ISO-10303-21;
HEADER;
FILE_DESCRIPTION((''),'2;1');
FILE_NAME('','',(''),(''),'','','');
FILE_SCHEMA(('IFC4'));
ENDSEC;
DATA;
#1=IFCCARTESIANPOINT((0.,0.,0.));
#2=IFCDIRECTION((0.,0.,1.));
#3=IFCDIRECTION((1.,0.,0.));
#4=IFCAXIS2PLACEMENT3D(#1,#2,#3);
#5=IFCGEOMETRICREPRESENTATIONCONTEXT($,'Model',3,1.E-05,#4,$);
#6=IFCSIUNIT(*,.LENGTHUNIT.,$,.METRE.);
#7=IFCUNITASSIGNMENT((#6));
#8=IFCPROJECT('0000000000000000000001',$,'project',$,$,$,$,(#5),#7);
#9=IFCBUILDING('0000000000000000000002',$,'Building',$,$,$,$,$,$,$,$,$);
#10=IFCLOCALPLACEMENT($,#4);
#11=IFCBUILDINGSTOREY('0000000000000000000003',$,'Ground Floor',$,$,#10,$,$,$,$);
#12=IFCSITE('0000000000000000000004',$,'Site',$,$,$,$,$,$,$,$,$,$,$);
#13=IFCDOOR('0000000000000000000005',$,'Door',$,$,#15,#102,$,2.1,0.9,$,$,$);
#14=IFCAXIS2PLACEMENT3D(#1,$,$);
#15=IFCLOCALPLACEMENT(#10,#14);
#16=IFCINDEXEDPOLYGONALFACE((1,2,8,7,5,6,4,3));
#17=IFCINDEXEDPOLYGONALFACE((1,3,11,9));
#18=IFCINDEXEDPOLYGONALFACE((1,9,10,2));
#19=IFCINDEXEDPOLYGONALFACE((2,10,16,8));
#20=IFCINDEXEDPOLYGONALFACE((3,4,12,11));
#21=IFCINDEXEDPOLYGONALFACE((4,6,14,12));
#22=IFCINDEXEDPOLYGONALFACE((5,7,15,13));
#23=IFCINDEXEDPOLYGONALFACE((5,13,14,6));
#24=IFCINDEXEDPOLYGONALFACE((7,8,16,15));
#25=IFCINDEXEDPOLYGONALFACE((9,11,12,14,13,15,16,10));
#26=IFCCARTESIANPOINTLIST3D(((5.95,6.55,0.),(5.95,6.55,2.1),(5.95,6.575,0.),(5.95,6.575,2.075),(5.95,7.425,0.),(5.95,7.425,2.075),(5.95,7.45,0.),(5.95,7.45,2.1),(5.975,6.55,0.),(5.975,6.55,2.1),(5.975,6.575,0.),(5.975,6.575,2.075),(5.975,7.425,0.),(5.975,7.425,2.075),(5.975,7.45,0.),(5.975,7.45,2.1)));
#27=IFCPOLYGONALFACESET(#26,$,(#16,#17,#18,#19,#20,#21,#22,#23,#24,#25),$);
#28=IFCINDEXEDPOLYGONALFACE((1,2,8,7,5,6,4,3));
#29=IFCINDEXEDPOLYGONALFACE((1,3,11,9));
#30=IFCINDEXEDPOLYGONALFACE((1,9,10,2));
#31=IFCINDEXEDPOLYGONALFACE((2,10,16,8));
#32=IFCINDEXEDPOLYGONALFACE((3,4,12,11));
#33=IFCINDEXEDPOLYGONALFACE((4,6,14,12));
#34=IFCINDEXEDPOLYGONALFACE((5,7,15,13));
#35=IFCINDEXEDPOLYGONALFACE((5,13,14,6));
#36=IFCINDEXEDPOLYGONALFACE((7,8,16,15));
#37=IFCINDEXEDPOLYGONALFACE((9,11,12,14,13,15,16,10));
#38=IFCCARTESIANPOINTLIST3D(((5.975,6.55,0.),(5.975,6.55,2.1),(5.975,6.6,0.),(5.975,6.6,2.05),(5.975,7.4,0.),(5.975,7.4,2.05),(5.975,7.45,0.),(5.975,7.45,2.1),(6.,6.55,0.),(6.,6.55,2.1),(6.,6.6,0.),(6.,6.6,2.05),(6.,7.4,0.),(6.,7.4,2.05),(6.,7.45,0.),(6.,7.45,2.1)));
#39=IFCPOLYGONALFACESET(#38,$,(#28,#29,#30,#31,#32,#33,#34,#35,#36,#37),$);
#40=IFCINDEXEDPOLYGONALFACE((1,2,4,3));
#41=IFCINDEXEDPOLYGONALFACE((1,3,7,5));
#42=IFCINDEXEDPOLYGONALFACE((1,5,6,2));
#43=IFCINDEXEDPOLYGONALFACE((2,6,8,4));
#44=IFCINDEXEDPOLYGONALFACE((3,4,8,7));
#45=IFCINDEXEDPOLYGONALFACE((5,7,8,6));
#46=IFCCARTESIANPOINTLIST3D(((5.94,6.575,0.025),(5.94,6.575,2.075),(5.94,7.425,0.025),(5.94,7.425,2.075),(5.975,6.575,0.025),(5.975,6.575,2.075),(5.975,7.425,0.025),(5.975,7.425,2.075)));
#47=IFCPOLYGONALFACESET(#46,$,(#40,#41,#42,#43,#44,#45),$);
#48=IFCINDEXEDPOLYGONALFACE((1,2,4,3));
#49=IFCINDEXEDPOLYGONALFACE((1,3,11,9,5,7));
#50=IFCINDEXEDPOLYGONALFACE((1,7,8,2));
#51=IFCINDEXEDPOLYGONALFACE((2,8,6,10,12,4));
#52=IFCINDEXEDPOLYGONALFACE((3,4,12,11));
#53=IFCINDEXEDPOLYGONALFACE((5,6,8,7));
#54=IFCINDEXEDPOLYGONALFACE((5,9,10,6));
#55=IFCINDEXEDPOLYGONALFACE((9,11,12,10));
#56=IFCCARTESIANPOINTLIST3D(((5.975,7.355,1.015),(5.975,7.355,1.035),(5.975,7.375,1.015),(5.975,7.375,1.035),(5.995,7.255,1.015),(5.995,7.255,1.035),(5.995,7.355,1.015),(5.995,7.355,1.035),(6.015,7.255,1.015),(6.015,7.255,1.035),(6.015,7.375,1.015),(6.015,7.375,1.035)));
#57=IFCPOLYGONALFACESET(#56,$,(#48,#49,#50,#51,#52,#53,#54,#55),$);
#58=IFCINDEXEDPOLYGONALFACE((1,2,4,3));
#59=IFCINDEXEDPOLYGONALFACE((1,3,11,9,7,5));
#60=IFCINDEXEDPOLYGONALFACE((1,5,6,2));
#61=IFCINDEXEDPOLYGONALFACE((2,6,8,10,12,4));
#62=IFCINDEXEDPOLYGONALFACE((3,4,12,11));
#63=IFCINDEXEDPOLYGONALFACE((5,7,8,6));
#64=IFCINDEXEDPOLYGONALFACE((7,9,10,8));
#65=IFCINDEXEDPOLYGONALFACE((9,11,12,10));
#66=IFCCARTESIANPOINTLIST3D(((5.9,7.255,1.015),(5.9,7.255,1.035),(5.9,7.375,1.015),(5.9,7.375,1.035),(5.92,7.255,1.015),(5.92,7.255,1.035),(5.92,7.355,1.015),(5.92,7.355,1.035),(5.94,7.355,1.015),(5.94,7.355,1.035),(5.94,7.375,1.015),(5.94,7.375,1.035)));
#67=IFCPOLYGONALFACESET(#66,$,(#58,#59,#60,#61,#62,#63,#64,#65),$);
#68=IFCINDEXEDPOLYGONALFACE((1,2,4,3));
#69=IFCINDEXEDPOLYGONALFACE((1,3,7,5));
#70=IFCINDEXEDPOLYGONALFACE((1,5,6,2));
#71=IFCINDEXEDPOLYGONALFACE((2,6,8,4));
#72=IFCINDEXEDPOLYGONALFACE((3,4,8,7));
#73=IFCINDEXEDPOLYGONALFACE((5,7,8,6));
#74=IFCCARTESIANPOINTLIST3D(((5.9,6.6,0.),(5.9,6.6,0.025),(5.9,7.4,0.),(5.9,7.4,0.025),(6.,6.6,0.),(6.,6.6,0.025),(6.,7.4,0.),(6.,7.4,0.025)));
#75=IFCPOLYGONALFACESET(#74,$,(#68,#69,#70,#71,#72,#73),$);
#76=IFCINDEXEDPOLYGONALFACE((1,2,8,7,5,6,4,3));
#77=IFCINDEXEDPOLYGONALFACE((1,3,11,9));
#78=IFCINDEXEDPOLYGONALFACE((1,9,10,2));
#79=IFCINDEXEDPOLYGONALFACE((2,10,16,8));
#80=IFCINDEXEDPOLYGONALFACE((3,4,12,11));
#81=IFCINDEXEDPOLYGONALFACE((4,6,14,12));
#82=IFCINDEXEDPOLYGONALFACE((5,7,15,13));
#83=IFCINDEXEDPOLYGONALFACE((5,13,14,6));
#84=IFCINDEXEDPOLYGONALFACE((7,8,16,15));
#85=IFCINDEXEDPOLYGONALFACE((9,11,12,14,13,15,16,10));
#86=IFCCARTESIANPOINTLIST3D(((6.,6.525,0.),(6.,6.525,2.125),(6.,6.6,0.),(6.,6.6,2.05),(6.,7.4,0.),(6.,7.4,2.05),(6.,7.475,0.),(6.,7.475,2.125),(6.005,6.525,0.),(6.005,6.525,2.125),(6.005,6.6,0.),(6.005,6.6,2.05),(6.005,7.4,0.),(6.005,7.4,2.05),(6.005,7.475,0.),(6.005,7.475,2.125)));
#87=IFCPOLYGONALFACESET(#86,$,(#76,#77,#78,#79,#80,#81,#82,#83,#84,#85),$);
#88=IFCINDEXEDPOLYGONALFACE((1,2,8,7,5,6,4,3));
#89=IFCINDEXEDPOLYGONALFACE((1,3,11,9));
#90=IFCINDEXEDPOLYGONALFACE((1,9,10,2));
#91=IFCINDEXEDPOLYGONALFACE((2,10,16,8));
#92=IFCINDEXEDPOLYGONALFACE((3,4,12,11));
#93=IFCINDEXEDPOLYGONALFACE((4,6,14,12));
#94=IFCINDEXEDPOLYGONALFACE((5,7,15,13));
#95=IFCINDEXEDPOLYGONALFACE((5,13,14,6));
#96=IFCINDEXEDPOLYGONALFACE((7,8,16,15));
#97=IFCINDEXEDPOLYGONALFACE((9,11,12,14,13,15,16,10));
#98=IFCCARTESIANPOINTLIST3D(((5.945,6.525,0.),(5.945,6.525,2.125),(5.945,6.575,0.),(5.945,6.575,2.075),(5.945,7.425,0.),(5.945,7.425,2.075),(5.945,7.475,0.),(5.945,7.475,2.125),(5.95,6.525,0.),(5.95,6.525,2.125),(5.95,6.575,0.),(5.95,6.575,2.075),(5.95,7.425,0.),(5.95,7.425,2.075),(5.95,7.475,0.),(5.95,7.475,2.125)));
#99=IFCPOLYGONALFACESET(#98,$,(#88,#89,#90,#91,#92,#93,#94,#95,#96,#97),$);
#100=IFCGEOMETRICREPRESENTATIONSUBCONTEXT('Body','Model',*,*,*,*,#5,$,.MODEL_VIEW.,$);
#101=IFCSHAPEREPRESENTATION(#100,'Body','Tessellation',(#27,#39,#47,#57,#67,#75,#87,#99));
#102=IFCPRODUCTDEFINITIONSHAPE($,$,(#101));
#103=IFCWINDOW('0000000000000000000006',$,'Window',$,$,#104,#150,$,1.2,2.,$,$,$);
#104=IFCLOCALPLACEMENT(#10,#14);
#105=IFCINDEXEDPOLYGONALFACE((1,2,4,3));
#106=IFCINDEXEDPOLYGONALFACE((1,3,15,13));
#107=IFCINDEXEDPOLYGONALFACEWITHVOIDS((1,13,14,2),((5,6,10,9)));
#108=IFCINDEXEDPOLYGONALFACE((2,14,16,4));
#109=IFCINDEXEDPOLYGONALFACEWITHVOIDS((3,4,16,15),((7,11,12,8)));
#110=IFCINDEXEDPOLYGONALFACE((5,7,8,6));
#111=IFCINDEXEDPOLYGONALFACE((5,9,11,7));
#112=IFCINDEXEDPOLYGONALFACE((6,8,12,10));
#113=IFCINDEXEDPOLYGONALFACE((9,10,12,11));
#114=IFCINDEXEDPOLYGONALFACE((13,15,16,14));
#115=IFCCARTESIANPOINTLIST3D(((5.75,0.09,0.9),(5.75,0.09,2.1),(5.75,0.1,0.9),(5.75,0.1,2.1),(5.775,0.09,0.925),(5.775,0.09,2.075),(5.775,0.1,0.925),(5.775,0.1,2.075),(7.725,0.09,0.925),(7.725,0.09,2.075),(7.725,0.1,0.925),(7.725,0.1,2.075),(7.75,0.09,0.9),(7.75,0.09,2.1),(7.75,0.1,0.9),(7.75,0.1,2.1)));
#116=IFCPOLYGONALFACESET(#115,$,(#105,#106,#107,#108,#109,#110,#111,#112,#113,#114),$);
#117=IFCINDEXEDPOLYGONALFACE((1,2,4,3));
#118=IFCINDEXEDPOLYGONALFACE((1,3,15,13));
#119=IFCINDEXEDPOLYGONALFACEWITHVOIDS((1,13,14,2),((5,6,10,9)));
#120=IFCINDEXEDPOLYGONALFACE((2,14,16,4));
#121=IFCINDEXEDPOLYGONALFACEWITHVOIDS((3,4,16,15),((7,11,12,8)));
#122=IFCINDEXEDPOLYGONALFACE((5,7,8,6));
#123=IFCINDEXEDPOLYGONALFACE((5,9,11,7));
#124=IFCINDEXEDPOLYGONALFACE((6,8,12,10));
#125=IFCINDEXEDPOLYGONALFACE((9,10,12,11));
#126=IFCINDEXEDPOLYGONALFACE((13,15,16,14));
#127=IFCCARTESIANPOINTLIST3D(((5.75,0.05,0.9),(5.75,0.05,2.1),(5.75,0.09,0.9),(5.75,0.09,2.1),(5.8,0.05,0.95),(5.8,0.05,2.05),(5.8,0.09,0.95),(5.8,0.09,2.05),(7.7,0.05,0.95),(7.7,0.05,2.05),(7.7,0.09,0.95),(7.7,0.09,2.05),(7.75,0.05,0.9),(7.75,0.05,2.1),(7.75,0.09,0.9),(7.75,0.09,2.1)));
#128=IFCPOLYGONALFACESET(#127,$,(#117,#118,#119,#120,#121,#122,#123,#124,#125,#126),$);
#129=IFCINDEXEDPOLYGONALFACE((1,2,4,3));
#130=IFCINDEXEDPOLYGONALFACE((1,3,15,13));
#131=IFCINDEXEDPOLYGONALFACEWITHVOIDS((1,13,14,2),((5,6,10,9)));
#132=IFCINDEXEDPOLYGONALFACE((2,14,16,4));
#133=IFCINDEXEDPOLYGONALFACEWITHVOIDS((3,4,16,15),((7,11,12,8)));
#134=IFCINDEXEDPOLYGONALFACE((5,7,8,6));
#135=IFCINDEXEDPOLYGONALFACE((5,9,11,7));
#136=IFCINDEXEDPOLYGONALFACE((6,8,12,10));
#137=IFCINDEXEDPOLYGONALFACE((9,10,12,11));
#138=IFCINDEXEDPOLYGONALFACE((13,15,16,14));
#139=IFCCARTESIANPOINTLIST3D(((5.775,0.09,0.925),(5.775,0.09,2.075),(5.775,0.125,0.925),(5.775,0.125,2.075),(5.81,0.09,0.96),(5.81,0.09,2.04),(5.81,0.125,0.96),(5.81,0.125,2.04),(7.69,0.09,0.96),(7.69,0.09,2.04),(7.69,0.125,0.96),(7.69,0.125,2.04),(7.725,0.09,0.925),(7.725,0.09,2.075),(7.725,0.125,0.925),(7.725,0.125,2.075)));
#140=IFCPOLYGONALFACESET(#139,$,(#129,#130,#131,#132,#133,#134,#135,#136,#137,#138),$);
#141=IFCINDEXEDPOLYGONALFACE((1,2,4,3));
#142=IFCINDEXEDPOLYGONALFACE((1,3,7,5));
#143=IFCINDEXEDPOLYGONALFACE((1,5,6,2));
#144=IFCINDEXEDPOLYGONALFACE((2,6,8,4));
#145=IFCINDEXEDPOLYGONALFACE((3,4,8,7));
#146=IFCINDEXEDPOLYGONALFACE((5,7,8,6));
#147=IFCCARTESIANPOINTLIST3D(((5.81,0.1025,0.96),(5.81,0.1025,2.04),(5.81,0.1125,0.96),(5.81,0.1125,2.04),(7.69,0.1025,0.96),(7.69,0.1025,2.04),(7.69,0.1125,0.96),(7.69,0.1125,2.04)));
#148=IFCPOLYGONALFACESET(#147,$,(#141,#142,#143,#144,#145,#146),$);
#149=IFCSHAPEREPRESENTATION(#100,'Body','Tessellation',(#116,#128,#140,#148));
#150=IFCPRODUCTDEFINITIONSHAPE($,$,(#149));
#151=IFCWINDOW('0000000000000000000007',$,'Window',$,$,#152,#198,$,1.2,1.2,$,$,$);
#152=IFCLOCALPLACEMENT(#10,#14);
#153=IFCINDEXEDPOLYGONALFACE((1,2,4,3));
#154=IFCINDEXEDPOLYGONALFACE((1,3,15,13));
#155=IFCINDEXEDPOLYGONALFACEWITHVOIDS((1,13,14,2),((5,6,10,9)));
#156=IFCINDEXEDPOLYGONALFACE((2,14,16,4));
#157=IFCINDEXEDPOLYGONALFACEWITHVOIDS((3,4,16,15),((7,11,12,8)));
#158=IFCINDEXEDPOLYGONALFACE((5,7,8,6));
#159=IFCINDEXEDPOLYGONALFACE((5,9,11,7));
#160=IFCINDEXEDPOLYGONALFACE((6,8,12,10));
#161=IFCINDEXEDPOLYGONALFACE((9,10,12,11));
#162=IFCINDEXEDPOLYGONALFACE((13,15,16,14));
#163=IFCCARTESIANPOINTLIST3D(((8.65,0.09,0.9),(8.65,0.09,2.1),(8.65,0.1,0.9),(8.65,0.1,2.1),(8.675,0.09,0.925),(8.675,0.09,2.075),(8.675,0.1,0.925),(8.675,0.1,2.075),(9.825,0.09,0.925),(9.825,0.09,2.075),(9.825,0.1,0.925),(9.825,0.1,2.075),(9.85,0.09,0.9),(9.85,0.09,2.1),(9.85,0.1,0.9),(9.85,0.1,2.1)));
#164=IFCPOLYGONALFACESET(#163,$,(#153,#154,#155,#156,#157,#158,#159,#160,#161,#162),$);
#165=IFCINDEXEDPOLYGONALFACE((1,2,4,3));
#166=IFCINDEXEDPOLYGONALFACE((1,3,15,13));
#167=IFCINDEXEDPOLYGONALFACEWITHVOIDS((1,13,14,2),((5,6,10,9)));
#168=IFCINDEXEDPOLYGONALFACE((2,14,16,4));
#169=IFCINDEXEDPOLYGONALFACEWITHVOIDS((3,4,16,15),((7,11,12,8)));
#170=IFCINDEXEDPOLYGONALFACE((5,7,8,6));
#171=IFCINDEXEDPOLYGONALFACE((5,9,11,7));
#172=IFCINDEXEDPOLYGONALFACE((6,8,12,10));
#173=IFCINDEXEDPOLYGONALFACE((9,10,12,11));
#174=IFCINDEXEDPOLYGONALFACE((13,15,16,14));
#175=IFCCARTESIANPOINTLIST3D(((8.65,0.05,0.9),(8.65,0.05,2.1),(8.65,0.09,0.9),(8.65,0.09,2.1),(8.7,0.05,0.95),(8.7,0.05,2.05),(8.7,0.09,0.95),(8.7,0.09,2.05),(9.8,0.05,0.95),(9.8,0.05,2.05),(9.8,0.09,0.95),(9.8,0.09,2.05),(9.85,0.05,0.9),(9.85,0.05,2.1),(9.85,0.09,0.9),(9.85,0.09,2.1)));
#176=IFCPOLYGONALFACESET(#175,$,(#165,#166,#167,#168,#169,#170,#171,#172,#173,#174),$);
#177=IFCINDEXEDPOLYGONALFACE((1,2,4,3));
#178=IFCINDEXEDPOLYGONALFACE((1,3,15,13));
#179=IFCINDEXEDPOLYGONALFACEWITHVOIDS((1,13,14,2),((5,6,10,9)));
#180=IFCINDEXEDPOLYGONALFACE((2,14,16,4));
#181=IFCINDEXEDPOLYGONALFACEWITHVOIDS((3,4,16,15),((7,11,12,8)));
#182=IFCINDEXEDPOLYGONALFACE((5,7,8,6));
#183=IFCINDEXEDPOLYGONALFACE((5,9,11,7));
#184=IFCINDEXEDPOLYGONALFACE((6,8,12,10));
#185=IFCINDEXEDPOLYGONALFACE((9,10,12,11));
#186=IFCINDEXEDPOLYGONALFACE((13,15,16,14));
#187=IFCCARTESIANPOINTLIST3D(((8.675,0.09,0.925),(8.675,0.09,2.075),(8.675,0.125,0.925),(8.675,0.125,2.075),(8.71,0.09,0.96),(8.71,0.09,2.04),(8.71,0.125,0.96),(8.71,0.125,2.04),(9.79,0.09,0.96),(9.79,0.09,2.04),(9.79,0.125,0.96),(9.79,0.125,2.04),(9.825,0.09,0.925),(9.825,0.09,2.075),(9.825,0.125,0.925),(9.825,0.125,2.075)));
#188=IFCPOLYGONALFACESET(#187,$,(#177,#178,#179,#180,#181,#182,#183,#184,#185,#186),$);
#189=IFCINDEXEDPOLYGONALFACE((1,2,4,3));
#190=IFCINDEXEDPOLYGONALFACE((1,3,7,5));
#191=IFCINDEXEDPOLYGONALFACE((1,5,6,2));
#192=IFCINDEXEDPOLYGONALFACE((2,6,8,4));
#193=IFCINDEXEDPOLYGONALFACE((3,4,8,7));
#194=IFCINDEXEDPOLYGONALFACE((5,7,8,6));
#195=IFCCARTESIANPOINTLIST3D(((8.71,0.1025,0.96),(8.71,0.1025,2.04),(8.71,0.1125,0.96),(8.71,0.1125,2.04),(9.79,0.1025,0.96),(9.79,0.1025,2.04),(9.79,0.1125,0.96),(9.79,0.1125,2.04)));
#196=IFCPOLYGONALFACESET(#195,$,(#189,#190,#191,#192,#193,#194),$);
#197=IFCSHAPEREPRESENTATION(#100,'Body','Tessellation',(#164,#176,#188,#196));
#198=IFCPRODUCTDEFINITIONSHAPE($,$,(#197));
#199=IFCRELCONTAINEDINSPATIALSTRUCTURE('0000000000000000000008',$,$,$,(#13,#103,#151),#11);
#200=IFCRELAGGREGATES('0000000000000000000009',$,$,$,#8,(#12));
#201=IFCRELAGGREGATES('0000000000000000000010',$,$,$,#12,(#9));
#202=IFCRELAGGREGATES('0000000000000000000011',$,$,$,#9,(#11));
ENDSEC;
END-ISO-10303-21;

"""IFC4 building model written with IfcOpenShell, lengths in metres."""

from ifc_helpers import new_model, si_unit, frame, origin_with_axes, place, context, subcontext, project, spatial, line, indexed_curve, outline, extrude, element, save


model = new_model("IFC4")

# Units and contexts
model_context = context("Model", 3, precision=1e-05, world=origin_with_axes())
body_context = subcontext(model_context, "Body", "Model", "MODEL_VIEW")
ifc_project = project(units=[si_unit("LENGTHUNIT", "METRE")], contexts=[model_context])

# Site, building, storey
site = spatial("IfcSite", under=ifc_project, Name="Site")
building = spatial("IfcBuilding", under=site, Name="Building")
storey_placement = place(None, origin_with_axes())
storey = spatial("IfcBuildingStorey", under=building, at=storey_placement, Name="Ground Floor")

# Door
door_1_placement = place(storey_placement, frame((6.0, 6.55, 0.0), z_axis=(0.0, 0.0, 1.0), x_axis=(0.0, 1.0, 0.0)))
element("IfcDoor", 1, at=door_1_placement, inside=storey, Name="Door", OverallHeight=2.1, OverallWidth=0.9, context=body_context, shape_type="SweptSolid", body=[
    extrude(outline(indexed_curve([(0.0, 0.0), (0.0, 2.1), (0.9, 2.1), (0.9, 0.0), (0.875, 0.0), (0.875, 2.075), (0.025, 2.075), (0.025, 0.0)], segments=[line(1, 2, 3, 4, 5, 6, 7, 8, 1)])), frame((0.0, 0.025, 0.0), z_axis=(0.0, -1.0, 0.0), x_axis=(1.0, 0.0, 0.0)), (0.0, 0.0, -1.0), 0.025),
    extrude(outline(indexed_curve([(0.0, 0.0), (0.0, 2.1), (0.9, 2.1), (0.9, 0.0), (0.85, 0.0), (0.85, 2.05), (0.05, 2.05), (0.05, 0.0)], segments=[line(1, 2, 3, 4, 5, 6, 7, 8, 1)])), frame((0.0, 0.0, 0.0), z_axis=(0.0, -1.0, 0.0), x_axis=(1.0, 0.0, 0.0)), (0.0, 0.0, -1.0), 0.025),
    extrude(outline(indexed_curve([(0.0, 0.0), (0.85, 0.0), (0.85, 0.035), (0.0, 0.035)], segments=[line(1, 2, 3, 4, 1)])), frame((0.025, 0.025, 0.025), z_axis=(0.0, 0.0, 1.0), x_axis=(1.0, 0.0, 0.0)), (0.0, 0.0, 1.0), 2.05),
    extrude(outline(indexed_curve([(0.0, 0.0), (0.0, -0.04), (-0.12, -0.04), (-0.12, -0.02), (-0.02, -0.02), (-0.02, 0.0)], segments=[line(1, 2, 3, 4, 5, 6, 1)])), frame((0.825, 0.025, 1.015), z_axis=(0.0, 0.0, 1.0), x_axis=(1.0, 0.0, 0.0)), (0.0, 0.0, 1.0), 0.02),
    extrude(outline(indexed_curve([(0.0, 0.0), (0.0, 0.04), (-0.12, 0.04), (-0.12, 0.02), (-0.02, 0.02), (-0.02, 0.0)], segments=[line(1, 2, 3, 4, 5, 6, 1)])), frame((0.825, 0.06, 1.015), z_axis=(0.0, 0.0, 1.0), x_axis=(1.0, 0.0, 0.0)), (0.0, 0.0, 1.0), 0.02),
    extrude(outline(indexed_curve([(0.0, 0.0), (0.8, 0.0), (0.8, 0.1), (0.0, 0.1)], segments=[line(1, 2, 3, 4, 1)])), frame((0.05, 0.0, 0.0), z_axis=(0.0, 0.0, 1.0), x_axis=(1.0, 0.0, 0.0)), (0.0, 0.0, 1.0), 0.025),
    extrude(outline(indexed_curve([(0.0, 0.0), (0.0, 2.125), (0.95, 2.125), (0.95, 0.0), (0.875, 0.0), (0.875, 2.05), (0.075, 2.05), (0.075, 0.0)], segments=[line(1, 2, 3, 4, 5, 6, 7, 8, 1)])), frame((-0.025, -0.005, 0.0), z_axis=(0.0, -1.0, 0.0), x_axis=(1.0, 0.0, 0.0)), (0.0, 0.0, -1.0), 0.005),
    extrude(outline(indexed_curve([(0.0, 0.0), (0.0, 2.125), (0.95, 2.125), (0.95, 0.0), (0.9, 0.0), (0.9, 2.075), (0.05, 2.075), (0.05, 0.0)], segments=[line(1, 2, 3, 4, 5, 6, 7, 8, 1)])), frame((-0.025, 0.05, 0.0), z_axis=(0.0, -1.0, 0.0), x_axis=(1.0, 0.0, 0.0)), (0.0, 0.0, -1.0), 0.005),
])

# Windows
window_1_placement = place(storey_placement, frame((5.75, 0.0, 0.9), z_axis=(0.0, 0.0, 1.0), x_axis=(1.0, 0.0, 0.0)))
element("IfcWindow", 2, at=window_1_placement, inside=storey, Name="Window", OverallHeight=1.2, OverallWidth=2.0, context=body_context, shape_type="SweptSolid", body=[
    extrude(outline(indexed_curve([(0.0, 0.0), (2.0, 0.0), (2.0, 1.2), (0.0, 1.2)], segments=[line(1, 2, 3, 4, 1)]), holes=[indexed_curve([(0.025, 0.025), (1.975, 0.025), (1.975, 1.175), (0.025, 1.175)], segments=[line(1, 2, 3, 4, 1)])]), frame((0.0, 0.09, 0.0), z_axis=(0.0, -1.0, 0.0), x_axis=(1.0, 0.0, 0.0)), (0.0, 0.0, -1.0), 0.01),
    extrude(outline(indexed_curve([(0.0, 0.0), (2.0, 0.0), (2.0, 1.2), (0.0, 1.2)], segments=[line(1, 2, 3, 4, 1)]), holes=[indexed_curve([(0.05, 0.05), (1.95, 0.05), (1.95, 1.15), (0.05, 1.15)], segments=[line(1, 2, 3, 4, 1)])]), frame((0.0, 0.05, 0.0), z_axis=(0.0, -1.0, 0.0), x_axis=(1.0, 0.0, 0.0)), (0.0, 0.0, -1.0), 0.04),
    extrude(outline(indexed_curve([(0.0, 0.0), (1.95, 0.0), (1.95, 1.15), (0.0, 1.15)], segments=[line(1, 2, 3, 4, 1)]), holes=[indexed_curve([(0.035, 0.035), (1.915, 0.035), (1.915, 1.115), (0.035, 1.115)], segments=[line(1, 2, 3, 4, 1)])]), frame((0.025, 0.09, 0.025), z_axis=(0.0, -1.0, 0.0), x_axis=(1.0, 0.0, 0.0)), (0.0, 0.0, -1.0), 0.035),
    extrude(outline(indexed_curve([(0.035, 0.035), (1.915, 0.035), (1.915, 1.115), (0.035, 1.115)], segments=[line(1, 2, 3, 4, 1)])), frame((0.025, 0.1025, 0.025), z_axis=(0.0, -1.0, 0.0), x_axis=(1.0, 0.0, 0.0)), (0.0, 0.0, -1.0), 0.01),
])
for number, where, z_axis, x_axis, name in (
    (3, (8.65, 0.0, 0.9), (0.0, 0.0, 1.0), (1.0, 0.0, 0.0), "Window"),
):
    element("IfcWindow", number, at=place(storey_placement, frame(where, z_axis=z_axis, x_axis=x_axis)), inside=storey, Name=name, OverallHeight=1.2, OverallWidth=1.2, context=body_context, shape_type="SweptSolid", body=[
        extrude(outline(indexed_curve([(0.0, 0.0), (1.2, 0.0), (1.2, 1.2), (0.0, 1.2)], segments=[line(1, 2, 3, 4, 1)]), holes=[indexed_curve([(0.025, 0.025), (1.175, 0.025), (1.175, 1.175), (0.025, 1.175)], segments=[line(1, 2, 3, 4, 1)])]), frame((0.0, 0.09, 0.0), z_axis=(0.0, -1.0, 0.0), x_axis=(1.0, 0.0, 0.0)), (0.0, 0.0, -1.0), 0.01),
        extrude(outline(indexed_curve([(0.0, 0.0), (1.2, 0.0), (1.2, 1.2), (0.0, 1.2)], segments=[line(1, 2, 3, 4, 1)]), holes=[indexed_curve([(0.05, 0.05), (1.15, 0.05), (1.15, 1.15), (0.05, 1.15)], segments=[line(1, 2, 3, 4, 1)])]), frame((0.0, 0.05, 0.0), z_axis=(0.0, -1.0, 0.0), x_axis=(1.0, 0.0, 0.0)), (0.0, 0.0, -1.0), 0.04),
        extrude(outline(indexed_curve([(0.0, 0.0), (1.15, 0.0), (1.15, 1.15), (0.0, 1.15)], segments=[line(1, 2, 3, 4, 1)]), holes=[indexed_curve([(0.035, 0.035), (1.115, 0.035), (1.115, 1.115), (0.035, 1.115)], segments=[line(1, 2, 3, 4, 1)])]), frame((0.025, 0.09, 0.025), z_axis=(0.0, -1.0, 0.0), x_axis=(1.0, 0.0, 0.0)), (0.0, 0.0, -1.0), 0.035),
        extrude(outline(indexed_curve([(0.035, 0.035), (1.115, 0.035), (1.115, 1.115), (0.035, 1.115)], segments=[line(1, 2, 3, 4, 1)])), frame((0.025, 0.1025, 0.025), z_axis=(0.0, -1.0, 0.0), x_axis=(1.0, 0.0, 0.0)), (0.0, 0.0, -1.0), 0.01),
    ])

save(model, "model.ifc")
